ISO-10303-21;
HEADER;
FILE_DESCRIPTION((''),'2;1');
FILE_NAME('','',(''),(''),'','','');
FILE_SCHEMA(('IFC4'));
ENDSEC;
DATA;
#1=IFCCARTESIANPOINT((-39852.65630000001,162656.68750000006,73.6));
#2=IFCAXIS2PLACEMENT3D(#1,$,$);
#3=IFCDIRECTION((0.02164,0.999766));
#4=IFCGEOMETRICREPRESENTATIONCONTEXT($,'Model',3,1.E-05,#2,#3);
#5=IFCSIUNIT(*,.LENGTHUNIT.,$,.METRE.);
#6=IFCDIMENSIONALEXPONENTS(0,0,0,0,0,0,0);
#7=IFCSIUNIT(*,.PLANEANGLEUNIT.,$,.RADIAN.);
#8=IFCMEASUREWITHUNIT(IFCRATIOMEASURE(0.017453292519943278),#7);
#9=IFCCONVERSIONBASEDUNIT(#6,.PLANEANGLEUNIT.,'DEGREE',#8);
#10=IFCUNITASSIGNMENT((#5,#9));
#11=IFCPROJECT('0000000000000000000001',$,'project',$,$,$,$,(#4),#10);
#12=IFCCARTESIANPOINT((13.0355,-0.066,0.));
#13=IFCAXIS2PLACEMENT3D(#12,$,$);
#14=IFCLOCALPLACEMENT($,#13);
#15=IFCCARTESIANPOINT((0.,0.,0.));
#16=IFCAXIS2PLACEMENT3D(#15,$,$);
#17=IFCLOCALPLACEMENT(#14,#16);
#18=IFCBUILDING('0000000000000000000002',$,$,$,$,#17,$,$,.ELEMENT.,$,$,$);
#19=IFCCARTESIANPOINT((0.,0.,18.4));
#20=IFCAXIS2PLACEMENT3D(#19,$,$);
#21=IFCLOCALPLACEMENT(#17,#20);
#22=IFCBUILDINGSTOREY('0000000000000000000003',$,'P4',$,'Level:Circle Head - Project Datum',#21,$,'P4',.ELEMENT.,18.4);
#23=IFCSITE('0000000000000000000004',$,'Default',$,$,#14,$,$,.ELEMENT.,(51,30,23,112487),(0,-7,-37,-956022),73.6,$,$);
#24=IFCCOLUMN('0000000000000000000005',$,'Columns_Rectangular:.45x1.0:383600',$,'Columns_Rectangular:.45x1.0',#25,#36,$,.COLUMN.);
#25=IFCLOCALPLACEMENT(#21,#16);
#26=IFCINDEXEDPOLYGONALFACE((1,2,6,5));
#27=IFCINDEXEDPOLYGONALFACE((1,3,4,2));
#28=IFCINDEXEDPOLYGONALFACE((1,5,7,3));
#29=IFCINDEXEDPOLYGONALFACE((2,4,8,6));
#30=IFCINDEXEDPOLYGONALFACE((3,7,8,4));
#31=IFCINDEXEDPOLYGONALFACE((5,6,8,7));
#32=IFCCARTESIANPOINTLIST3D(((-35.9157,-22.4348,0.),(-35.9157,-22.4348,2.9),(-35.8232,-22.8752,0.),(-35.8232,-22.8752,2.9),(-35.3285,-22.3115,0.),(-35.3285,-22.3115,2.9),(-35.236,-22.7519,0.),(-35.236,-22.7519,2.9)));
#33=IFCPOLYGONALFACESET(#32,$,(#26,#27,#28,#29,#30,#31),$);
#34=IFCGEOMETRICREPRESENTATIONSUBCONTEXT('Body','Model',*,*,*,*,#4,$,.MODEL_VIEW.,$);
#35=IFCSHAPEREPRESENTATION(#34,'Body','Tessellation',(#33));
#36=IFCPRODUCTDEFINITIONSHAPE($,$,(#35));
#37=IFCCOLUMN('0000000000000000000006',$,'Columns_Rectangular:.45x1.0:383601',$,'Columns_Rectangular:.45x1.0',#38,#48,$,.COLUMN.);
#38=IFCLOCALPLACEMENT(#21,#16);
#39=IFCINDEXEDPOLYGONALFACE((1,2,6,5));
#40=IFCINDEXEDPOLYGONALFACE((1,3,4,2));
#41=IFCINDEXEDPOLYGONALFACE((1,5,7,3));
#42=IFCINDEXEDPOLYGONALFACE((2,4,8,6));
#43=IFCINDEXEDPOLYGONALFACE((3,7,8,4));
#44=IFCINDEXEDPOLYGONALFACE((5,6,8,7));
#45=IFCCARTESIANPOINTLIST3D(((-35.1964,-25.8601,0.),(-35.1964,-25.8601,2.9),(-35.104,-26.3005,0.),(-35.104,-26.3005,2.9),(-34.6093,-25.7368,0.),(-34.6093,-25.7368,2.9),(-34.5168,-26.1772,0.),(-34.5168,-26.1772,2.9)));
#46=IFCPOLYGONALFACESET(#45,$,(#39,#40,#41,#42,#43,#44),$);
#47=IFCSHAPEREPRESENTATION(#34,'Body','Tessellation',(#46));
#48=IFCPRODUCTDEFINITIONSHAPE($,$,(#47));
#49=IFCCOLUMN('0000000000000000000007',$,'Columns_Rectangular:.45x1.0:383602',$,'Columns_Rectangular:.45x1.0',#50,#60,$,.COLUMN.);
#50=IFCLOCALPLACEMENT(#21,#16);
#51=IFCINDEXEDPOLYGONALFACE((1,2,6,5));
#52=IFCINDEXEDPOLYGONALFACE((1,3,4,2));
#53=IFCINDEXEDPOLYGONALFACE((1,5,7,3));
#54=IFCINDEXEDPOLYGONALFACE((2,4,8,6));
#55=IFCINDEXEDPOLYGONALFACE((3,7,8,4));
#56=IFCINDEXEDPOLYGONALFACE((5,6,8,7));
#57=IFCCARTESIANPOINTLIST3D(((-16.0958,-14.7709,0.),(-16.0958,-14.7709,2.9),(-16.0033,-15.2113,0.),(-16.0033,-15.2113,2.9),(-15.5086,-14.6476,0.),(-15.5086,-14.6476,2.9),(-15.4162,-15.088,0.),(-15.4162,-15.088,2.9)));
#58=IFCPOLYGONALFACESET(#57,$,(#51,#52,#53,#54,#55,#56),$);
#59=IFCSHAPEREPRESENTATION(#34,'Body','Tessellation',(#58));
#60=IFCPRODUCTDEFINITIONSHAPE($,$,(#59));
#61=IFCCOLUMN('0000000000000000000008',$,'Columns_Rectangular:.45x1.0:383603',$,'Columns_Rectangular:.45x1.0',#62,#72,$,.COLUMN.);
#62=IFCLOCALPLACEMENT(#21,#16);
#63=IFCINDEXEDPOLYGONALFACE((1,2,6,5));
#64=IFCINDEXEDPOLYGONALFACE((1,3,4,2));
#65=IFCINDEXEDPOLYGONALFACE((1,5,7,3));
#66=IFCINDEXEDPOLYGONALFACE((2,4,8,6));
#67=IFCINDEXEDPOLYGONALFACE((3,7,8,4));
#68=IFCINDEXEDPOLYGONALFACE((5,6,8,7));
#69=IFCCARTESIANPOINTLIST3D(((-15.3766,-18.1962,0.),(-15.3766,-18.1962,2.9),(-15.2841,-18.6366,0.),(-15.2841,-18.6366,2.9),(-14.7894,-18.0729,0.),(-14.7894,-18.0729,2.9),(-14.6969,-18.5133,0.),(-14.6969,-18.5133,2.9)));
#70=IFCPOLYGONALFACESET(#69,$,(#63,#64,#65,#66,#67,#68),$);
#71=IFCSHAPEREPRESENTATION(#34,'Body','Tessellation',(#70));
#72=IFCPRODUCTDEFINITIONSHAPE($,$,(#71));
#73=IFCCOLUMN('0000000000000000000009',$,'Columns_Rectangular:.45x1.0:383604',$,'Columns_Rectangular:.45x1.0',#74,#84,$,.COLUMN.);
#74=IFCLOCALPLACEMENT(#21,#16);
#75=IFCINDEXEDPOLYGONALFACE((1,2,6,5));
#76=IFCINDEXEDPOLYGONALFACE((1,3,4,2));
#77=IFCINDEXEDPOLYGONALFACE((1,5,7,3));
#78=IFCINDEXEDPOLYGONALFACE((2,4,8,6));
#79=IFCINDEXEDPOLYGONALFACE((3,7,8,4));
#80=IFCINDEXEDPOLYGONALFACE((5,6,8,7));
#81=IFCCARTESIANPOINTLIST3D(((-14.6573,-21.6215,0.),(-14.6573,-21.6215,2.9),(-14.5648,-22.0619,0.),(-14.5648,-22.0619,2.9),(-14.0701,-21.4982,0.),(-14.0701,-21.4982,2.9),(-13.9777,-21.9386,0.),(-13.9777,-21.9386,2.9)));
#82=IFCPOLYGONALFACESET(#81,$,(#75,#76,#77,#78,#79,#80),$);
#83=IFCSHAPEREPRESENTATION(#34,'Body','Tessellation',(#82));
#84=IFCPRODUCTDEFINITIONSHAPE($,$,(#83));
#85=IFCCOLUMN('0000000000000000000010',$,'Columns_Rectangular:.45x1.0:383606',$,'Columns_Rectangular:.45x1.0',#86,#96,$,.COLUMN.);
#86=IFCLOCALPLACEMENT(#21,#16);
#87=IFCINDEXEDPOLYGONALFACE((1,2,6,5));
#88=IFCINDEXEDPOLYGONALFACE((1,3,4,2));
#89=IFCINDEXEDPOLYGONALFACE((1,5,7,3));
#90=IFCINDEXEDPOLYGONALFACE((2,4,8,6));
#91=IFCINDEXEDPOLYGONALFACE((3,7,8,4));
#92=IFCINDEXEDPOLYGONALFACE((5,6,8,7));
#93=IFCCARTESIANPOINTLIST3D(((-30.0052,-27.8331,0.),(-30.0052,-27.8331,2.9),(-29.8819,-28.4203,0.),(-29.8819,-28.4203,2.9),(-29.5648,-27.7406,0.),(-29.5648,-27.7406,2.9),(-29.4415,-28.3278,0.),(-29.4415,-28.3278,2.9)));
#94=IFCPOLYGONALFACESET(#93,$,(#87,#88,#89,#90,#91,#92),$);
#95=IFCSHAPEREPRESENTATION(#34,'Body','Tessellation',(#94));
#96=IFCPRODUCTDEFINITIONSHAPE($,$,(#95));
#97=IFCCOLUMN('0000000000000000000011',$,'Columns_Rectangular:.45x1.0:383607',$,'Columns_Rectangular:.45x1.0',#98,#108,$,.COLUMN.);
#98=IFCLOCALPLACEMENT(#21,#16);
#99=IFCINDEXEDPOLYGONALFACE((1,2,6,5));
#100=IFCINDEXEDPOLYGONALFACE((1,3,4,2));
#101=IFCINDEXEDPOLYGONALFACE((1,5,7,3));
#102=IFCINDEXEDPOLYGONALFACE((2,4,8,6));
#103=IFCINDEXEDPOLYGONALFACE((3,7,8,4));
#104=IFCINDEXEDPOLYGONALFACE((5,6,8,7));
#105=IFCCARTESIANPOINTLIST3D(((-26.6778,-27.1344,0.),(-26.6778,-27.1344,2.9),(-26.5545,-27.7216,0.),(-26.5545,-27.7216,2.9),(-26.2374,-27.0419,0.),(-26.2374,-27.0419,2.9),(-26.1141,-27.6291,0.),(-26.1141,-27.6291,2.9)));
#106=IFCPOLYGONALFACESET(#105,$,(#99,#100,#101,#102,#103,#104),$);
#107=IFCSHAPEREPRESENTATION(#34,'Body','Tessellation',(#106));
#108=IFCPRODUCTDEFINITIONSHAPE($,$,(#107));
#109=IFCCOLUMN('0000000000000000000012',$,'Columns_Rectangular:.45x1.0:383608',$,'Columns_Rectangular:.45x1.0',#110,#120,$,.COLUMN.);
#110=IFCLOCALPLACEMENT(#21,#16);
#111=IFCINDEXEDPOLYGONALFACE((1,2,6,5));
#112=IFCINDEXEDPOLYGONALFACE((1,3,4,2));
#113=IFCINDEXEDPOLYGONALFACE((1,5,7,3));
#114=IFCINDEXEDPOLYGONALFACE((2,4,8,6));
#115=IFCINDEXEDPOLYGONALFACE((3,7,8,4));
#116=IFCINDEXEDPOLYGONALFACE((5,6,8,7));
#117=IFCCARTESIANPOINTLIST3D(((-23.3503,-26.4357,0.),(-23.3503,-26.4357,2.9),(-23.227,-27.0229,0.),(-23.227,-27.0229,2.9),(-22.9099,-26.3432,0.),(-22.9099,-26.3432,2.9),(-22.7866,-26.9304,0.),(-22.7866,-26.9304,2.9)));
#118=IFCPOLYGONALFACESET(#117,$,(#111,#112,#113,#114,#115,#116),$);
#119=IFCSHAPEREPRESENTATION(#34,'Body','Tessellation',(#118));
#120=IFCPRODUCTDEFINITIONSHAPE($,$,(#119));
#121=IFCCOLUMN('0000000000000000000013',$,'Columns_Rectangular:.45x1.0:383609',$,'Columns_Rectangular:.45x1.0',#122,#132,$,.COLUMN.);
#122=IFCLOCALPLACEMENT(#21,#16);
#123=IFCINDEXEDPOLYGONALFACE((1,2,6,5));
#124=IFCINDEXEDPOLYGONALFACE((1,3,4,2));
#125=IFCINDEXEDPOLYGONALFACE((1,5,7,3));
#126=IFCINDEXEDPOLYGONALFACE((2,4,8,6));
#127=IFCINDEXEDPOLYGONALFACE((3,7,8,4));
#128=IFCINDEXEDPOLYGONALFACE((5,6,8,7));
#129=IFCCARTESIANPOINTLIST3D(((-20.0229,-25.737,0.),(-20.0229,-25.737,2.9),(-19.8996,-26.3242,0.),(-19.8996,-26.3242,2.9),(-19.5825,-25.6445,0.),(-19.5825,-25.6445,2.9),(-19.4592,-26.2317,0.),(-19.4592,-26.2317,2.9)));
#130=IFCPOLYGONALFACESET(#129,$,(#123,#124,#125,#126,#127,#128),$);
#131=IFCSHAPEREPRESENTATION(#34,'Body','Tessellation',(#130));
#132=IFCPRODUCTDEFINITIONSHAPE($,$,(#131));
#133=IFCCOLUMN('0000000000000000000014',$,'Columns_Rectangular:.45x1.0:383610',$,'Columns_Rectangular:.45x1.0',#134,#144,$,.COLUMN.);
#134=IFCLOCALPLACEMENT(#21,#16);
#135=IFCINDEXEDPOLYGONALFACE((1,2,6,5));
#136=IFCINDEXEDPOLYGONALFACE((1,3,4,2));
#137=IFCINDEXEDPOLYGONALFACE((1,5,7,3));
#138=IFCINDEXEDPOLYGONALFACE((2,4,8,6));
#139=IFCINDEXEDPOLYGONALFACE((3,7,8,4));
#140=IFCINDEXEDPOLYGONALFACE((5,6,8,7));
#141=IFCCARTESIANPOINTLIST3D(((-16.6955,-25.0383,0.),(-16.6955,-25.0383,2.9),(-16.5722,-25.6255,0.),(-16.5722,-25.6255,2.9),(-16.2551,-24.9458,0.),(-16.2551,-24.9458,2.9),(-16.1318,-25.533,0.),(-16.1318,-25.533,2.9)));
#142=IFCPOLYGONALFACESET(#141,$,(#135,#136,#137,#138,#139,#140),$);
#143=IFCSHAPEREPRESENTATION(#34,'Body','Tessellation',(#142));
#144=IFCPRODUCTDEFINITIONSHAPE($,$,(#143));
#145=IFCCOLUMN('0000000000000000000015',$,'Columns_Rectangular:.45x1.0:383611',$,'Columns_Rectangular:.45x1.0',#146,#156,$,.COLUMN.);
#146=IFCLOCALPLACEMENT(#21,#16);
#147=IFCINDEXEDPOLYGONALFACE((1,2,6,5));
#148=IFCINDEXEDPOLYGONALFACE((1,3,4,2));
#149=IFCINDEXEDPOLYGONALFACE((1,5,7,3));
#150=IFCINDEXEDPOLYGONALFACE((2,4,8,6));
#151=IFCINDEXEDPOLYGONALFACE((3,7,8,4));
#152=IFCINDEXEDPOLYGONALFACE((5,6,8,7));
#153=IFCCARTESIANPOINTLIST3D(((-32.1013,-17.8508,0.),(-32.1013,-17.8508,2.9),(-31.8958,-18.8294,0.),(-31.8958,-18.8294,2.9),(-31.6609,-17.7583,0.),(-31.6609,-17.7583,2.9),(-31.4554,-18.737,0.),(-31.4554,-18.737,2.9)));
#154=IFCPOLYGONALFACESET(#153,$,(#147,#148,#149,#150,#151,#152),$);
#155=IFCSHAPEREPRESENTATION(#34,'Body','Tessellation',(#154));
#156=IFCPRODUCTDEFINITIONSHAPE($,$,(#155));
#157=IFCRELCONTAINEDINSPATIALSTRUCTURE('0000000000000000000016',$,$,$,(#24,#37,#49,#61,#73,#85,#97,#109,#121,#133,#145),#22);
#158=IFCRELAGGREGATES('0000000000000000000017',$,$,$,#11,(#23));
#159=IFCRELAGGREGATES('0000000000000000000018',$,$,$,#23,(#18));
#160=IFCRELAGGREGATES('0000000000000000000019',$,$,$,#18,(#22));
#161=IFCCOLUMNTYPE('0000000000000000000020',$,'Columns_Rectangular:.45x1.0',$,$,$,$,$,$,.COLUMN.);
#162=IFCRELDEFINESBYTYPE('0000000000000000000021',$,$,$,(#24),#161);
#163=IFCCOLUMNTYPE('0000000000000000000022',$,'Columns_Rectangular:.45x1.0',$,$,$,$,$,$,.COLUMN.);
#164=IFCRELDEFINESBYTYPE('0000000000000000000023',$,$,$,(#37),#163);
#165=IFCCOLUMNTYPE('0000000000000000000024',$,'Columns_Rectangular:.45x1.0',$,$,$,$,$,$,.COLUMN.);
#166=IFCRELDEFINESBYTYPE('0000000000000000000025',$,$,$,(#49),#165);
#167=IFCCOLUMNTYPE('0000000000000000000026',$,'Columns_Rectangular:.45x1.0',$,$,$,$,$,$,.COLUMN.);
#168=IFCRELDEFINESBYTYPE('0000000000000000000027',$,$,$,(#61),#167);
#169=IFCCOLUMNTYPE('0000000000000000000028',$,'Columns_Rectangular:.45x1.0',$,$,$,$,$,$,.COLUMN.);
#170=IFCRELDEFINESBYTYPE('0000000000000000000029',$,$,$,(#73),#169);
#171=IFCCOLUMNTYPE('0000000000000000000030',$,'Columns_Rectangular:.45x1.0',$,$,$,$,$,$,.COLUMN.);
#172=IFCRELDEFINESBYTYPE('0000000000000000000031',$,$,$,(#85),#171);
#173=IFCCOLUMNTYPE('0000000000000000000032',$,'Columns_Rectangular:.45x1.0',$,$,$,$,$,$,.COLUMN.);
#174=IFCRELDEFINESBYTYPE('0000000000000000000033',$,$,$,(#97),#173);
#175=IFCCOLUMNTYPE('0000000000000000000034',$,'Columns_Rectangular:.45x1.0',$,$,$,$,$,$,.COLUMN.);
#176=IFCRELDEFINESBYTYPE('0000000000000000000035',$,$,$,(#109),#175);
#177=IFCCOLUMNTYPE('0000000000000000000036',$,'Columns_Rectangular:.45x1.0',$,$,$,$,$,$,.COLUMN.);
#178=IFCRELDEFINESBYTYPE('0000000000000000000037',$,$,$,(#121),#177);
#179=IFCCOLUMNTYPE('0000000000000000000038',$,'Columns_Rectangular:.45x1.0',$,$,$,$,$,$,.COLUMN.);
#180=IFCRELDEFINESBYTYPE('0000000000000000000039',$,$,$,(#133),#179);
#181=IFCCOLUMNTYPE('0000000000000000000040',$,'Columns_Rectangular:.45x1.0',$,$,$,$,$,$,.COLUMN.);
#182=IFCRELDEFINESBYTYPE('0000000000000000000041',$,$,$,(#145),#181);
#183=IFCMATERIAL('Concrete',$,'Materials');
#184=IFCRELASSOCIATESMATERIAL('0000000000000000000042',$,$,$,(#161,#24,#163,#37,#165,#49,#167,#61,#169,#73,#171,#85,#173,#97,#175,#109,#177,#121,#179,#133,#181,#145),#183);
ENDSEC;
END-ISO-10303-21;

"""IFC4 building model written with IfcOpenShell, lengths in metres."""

from ifc_helpers import new_model, entity, si_unit, converted_unit, direction, frame, origin, place, context, subcontext, project, spatial, indexed_curve, outline, extrude, source, transform, mapped, material, type_object, type_shapes, element, save


model = new_model("IFC4")

# Units and contexts
model_context = context("Model", 3, precision=1e-05, world=frame((-39852.65630000001, 162656.68750000006, 73.6)), true_north=direction((0.02164, 0.999766)))
body_context = subcontext(model_context, "Body", "Model", "MODEL_VIEW")
ifc_project = project(units=[si_unit("LENGTHUNIT", "METRE"), converted_unit("PLANEANGLEUNIT", "DEGREE", entity("IfcRatioMeasure", 0.017453292519943278), si_unit("PLANEANGLEUNIT", "RADIAN"), dimensions=[0, 0, 0, 0, 0, 0, 0])], contexts=[model_context])

# Site, building, storey
site_placement = place(None, frame((13.0355, -0.066, 0.0)))
site = spatial("IfcSite", under=ifc_project, at=site_placement, Name="Default", CompositionType="ELEMENT", RefLatitude=(51, 30, 23, 112487), RefLongitude=(0, -7, -37, -956022), RefElevation=73.6)
building_placement = place(site_placement, origin())
building = spatial("IfcBuilding", under=site, at=building_placement, CompositionType="ELEMENT")
storey_placement = place(building_placement, frame((0.0, 0.0, 18.4)))
storey = spatial("IfcBuildingStorey", under=building, at=storey_placement, Name="P4", ObjectType="Level:Circle Head - Project Datum", LongName="P4", CompositionType="ELEMENT", Elevation=18.4)

# Columns
ifc_material = material(Name="Concrete", Category="Materials")
column_type_1 = type_object("IfcColumnType", Name="Columns_Rectangular:.45x1.0", PredefinedType="COLUMN", material=ifc_material)
shared_shape_1 = source(origin(), body_context, "Body", "SweptSolid", [
    extrude(outline(indexed_curve([(-0.3, -0.225), (0.3, -0.225), (0.3, 0.225), (-0.3, 0.225), (-0.3, -0.225)], self_intersect=False)), frame((-35.5759, -22.5933, 18.4), z_axis=(0.0, 0.0, 1.0), x_axis=(-0.978657, -0.2055, 0.0)), (0.0, 0.0, 1.0), 2.9),
])
type_shapes(column_type_1, [shared_shape_1])
column_1_placement = place(storey_placement, frame((0.0, 0.0, -18.4)))
element("IfcColumn", 1, at=column_1_placement, inside=storey, type_object=column_type_1, material=ifc_material, Name="Columns_Rectangular:.45x1.0:383600", ObjectType="Columns_Rectangular:.45x1.0", PredefinedType="COLUMN", context=body_context, shape_type="MappedRepresentation", body=[
    mapped(shared_shape_1, transform((0.0, 0.0, 0.0), scale=1.0)),
])
column_type_2 = type_object("IfcColumnType", Name="Columns_Rectangular:.45x1.0", PredefinedType="COLUMN", material=ifc_material)
shared_shape_2 = source(origin(), body_context, "Body", "SweptSolid", [
    extrude(outline(indexed_curve([(-0.3, -0.225), (0.3, -0.225), (0.3, 0.225), (-0.3, 0.225), (-0.3, -0.225)], self_intersect=False)), frame((-34.8566, -26.0186, 18.4), z_axis=(0.0, 0.0, 1.0), x_axis=(-0.978657, -0.2055, 0.0)), (0.0, 0.0, 1.0), 2.9),
])
type_shapes(column_type_2, [shared_shape_2])
column_2_placement = place(storey_placement, frame((0.0, 0.0, -18.4)))
element("IfcColumn", 2, at=column_2_placement, inside=storey, type_object=column_type_2, material=ifc_material, Name="Columns_Rectangular:.45x1.0:383601", ObjectType="Columns_Rectangular:.45x1.0", PredefinedType="COLUMN", context=body_context, shape_type="MappedRepresentation", body=[
    mapped(shared_shape_2, transform((0.0, 0.0, 0.0), scale=1.0)),
])
column_type_3 = type_object("IfcColumnType", Name="Columns_Rectangular:.45x1.0", PredefinedType="COLUMN", material=ifc_material)
shared_shape_3 = source(origin(), body_context, "Body", "SweptSolid", [
    extrude(outline(indexed_curve([(-0.3, -0.225), (0.3, -0.225), (0.3, 0.225), (-0.3, 0.225), (-0.3, -0.225)], self_intersect=False)), frame((-15.756, -14.9295, 18.4), z_axis=(0.0, 0.0, 1.0), x_axis=(-0.978657, -0.2055, 0.0)), (0.0, 0.0, 1.0), 2.9),
])
type_shapes(column_type_3, [shared_shape_3])
column_3_placement = place(storey_placement, frame((0.0, 0.0, -18.4)))
element("IfcColumn", 3, at=column_3_placement, inside=storey, type_object=column_type_3, material=ifc_material, Name="Columns_Rectangular:.45x1.0:383602", ObjectType="Columns_Rectangular:.45x1.0", PredefinedType="COLUMN", context=body_context, shape_type="MappedRepresentation", body=[
    mapped(shared_shape_3, transform((0.0, 0.0, 0.0), scale=1.0)),
])
column_type_4 = type_object("IfcColumnType", Name="Columns_Rectangular:.45x1.0", PredefinedType="COLUMN", material=ifc_material)
shared_shape_4 = source(origin(), body_context, "Body", "SweptSolid", [
    extrude(outline(indexed_curve([(-0.3, -0.225), (0.3, -0.225), (0.3, 0.225), (-0.3, 0.225), (-0.3, -0.225)], self_intersect=False)), frame((-15.0367, -18.3548, 18.4), z_axis=(0.0, 0.0, 1.0), x_axis=(-0.978657, -0.2055, 0.0)), (0.0, 0.0, 1.0), 2.9),
])
type_shapes(column_type_4, [shared_shape_4])
column_4_placement = place(storey_placement, frame((0.0, 0.0, -18.4)))
element("IfcColumn", 4, at=column_4_placement, inside=storey, type_object=column_type_4, material=ifc_material, Name="Columns_Rectangular:.45x1.0:383603", ObjectType="Columns_Rectangular:.45x1.0", PredefinedType="COLUMN", context=body_context, shape_type="MappedRepresentation", body=[
    mapped(shared_shape_4, transform((0.0, 0.0, 0.0), scale=1.0)),
])
column_type_5 = type_object("IfcColumnType", Name="Columns_Rectangular:.45x1.0", PredefinedType="COLUMN", material=ifc_material)
shared_shape_5 = source(origin(), body_context, "Body", "SweptSolid", [
    extrude(outline(indexed_curve([(-0.3, -0.225), (0.3, -0.225), (0.3, 0.225), (-0.3, 0.225), (-0.3, -0.225)], self_intersect=False)), frame((-14.3175, -21.7801, 18.4), z_axis=(0.0, 0.0, 1.0), x_axis=(-0.978657, -0.2055, 0.0)), (0.0, 0.0, 1.0), 2.9),
])
type_shapes(column_type_5, [shared_shape_5])
column_5_placement = place(storey_placement, frame((0.0, 0.0, -18.4)))
element("IfcColumn", 5, at=column_5_placement, inside=storey, type_object=column_type_5, material=ifc_material, Name="Columns_Rectangular:.45x1.0:383604", ObjectType="Columns_Rectangular:.45x1.0", PredefinedType="COLUMN", context=body_context, shape_type="MappedRepresentation", body=[
    mapped(shared_shape_5, transform((0.0, 0.0, 0.0), scale=1.0)),
])
column_type_6 = type_object("IfcColumnType", Name="Columns_Rectangular:.45x1.0", PredefinedType="COLUMN", material=ifc_material)
shared_shape_6 = source(origin(), body_context, "Body", "SweptSolid", [
    extrude(outline(indexed_curve([(-0.3, -0.225), (0.3, -0.225), (0.3, 0.225), (-0.3, 0.225), (-0.3, -0.225)], self_intersect=False)), frame((-29.7234, -28.0804, 18.4), z_axis=(0.0, 0.0, 1.0), x_axis=(-0.2055, 0.978657, 0.0)), (0.0, 0.0, 1.0), 2.9),
])
type_shapes(column_type_6, [shared_shape_6])
column_6_placement = place(storey_placement, frame((0.0, 0.0, -18.4)))
element("IfcColumn", 6, at=column_6_placement, inside=storey, type_object=column_type_6, material=ifc_material, Name="Columns_Rectangular:.45x1.0:383606", ObjectType="Columns_Rectangular:.45x1.0", PredefinedType="COLUMN", context=body_context, shape_type="MappedRepresentation", body=[
    mapped(shared_shape_6, transform((0.0, 0.0, 0.0), scale=1.0)),
])
column_type_7 = type_object("IfcColumnType", Name="Columns_Rectangular:.45x1.0", PredefinedType="COLUMN", material=ifc_material)
shared_shape_7 = source(origin(), body_context, "Body", "SweptSolid", [
    extrude(outline(indexed_curve([(-0.3, -0.225), (0.3, -0.225), (0.3, 0.225), (-0.3, 0.225), (-0.3, -0.225)], self_intersect=False)), frame((-26.3959, -27.3817, 18.4), z_axis=(0.0, 0.0, 1.0), x_axis=(-0.2055, 0.978657, 0.0)), (0.0, 0.0, 1.0), 2.9),
])
type_shapes(column_type_7, [shared_shape_7])
column_7_placement = place(storey_placement, frame((0.0, 0.0, -18.4)))
element("IfcColumn", 7, at=column_7_placement, inside=storey, type_object=column_type_7, material=ifc_material, Name="Columns_Rectangular:.45x1.0:383607", ObjectType="Columns_Rectangular:.45x1.0", PredefinedType="COLUMN", context=body_context, shape_type="MappedRepresentation", body=[
    mapped(shared_shape_7, transform((0.0, 0.0, 0.0), scale=1.0)),
])
column_type_8 = type_object("IfcColumnType", Name="Columns_Rectangular:.45x1.0", PredefinedType="COLUMN", material=ifc_material)
shared_shape_8 = source(origin(), body_context, "Body", "SweptSolid", [
    extrude(outline(indexed_curve([(-0.3, -0.225), (0.3, -0.225), (0.3, 0.225), (-0.3, 0.225), (-0.3, -0.225)], self_intersect=False)), frame((-23.0685, -26.6831, 18.4), z_axis=(0.0, 0.0, 1.0), x_axis=(-0.2055, 0.978657, 0.0)), (0.0, 0.0, 1.0), 2.9),
])
type_shapes(column_type_8, [shared_shape_8])
column_8_placement = place(storey_placement, frame((0.0, 0.0, -18.4)))
element("IfcColumn", 8, at=column_8_placement, inside=storey, type_object=column_type_8, material=ifc_material, Name="Columns_Rectangular:.45x1.0:383608", ObjectType="Columns_Rectangular:.45x1.0", PredefinedType="COLUMN", context=body_context, shape_type="MappedRepresentation", body=[
    mapped(shared_shape_8, transform((0.0, 0.0, 0.0), scale=1.0)),
])
column_type_9 = type_object("IfcColumnType", Name="Columns_Rectangular:.45x1.0", PredefinedType="COLUMN", material=ifc_material)
shared_shape_9 = source(origin(), body_context, "Body", "SweptSolid", [
    extrude(outline(indexed_curve([(-0.3, -0.225), (0.3, -0.225), (0.3, 0.225), (-0.3, 0.225), (-0.3, -0.225)], self_intersect=False)), frame((-19.741, -25.9844, 18.4), z_axis=(0.0, 0.0, 1.0), x_axis=(-0.2055, 0.978657, 0.0)), (0.0, 0.0, 1.0), 2.9),
])
type_shapes(column_type_9, [shared_shape_9])
column_9_placement = place(storey_placement, frame((0.0, 0.0, -18.4)))
element("IfcColumn", 9, at=column_9_placement, inside=storey, type_object=column_type_9, material=ifc_material, Name="Columns_Rectangular:.45x1.0:383609", ObjectType="Columns_Rectangular:.45x1.0", PredefinedType="COLUMN", context=body_context, shape_type="MappedRepresentation", body=[
    mapped(shared_shape_9, transform((0.0, 0.0, 0.0), scale=1.0)),
])
column_type_10 = type_object("IfcColumnType", Name="Columns_Rectangular:.45x1.0", PredefinedType="COLUMN", material=ifc_material)
shared_shape_10 = source(origin(), body_context, "Body", "SweptSolid", [
    extrude(outline(indexed_curve([(-0.3, -0.225), (0.3, -0.225), (0.3, 0.225), (-0.3, 0.225), (-0.3, -0.225)], self_intersect=False)), frame((-16.4136, -25.2857, 18.4), z_axis=(0.0, 0.0, 1.0), x_axis=(-0.2055, 0.978657, 0.0)), (0.0, 0.0, 1.0), 2.9),
])
type_shapes(column_type_10, [shared_shape_10])
column_10_placement = place(storey_placement, frame((0.0, 0.0, -18.4)))
element("IfcColumn", 10, at=column_10_placement, inside=storey, type_object=column_type_10, material=ifc_material, Name="Columns_Rectangular:.45x1.0:383610", ObjectType="Columns_Rectangular:.45x1.0", PredefinedType="COLUMN", context=body_context, shape_type="MappedRepresentation", body=[
    mapped(shared_shape_10, transform((0.0, 0.0, 0.0), scale=1.0)),
])
column_type_11 = type_object("IfcColumnType", Name="Columns_Rectangular:.45x1.0", PredefinedType="COLUMN", material=ifc_material)
shared_shape_11 = source(origin(), body_context, "Body", "SweptSolid", [
    extrude(outline(indexed_curve([(-0.5, -0.225), (0.5, -0.225), (0.5, 0.225), (-0.5, 0.225), (-0.5, -0.225)], self_intersect=False)), frame((-31.7784, -18.2939, 18.4), z_axis=(0.0, 0.0, 1.0), x_axis=(-0.2055, 0.978657, 0.0)), (0.0, 0.0, 1.0), 2.9),
])
type_shapes(column_type_11, [shared_shape_11])
column_11_placement = place(storey_placement, frame((0.0, 0.0, -18.4)))
element("IfcColumn", 11, at=column_11_placement, inside=storey, type_object=column_type_11, material=ifc_material, Name="Columns_Rectangular:.45x1.0:383611", ObjectType="Columns_Rectangular:.45x1.0", PredefinedType="COLUMN", context=body_context, shape_type="MappedRepresentation", body=[
    mapped(shared_shape_11, transform((0.0, 0.0, 0.0), scale=1.0)),
])

save(model, "model.ifc")
